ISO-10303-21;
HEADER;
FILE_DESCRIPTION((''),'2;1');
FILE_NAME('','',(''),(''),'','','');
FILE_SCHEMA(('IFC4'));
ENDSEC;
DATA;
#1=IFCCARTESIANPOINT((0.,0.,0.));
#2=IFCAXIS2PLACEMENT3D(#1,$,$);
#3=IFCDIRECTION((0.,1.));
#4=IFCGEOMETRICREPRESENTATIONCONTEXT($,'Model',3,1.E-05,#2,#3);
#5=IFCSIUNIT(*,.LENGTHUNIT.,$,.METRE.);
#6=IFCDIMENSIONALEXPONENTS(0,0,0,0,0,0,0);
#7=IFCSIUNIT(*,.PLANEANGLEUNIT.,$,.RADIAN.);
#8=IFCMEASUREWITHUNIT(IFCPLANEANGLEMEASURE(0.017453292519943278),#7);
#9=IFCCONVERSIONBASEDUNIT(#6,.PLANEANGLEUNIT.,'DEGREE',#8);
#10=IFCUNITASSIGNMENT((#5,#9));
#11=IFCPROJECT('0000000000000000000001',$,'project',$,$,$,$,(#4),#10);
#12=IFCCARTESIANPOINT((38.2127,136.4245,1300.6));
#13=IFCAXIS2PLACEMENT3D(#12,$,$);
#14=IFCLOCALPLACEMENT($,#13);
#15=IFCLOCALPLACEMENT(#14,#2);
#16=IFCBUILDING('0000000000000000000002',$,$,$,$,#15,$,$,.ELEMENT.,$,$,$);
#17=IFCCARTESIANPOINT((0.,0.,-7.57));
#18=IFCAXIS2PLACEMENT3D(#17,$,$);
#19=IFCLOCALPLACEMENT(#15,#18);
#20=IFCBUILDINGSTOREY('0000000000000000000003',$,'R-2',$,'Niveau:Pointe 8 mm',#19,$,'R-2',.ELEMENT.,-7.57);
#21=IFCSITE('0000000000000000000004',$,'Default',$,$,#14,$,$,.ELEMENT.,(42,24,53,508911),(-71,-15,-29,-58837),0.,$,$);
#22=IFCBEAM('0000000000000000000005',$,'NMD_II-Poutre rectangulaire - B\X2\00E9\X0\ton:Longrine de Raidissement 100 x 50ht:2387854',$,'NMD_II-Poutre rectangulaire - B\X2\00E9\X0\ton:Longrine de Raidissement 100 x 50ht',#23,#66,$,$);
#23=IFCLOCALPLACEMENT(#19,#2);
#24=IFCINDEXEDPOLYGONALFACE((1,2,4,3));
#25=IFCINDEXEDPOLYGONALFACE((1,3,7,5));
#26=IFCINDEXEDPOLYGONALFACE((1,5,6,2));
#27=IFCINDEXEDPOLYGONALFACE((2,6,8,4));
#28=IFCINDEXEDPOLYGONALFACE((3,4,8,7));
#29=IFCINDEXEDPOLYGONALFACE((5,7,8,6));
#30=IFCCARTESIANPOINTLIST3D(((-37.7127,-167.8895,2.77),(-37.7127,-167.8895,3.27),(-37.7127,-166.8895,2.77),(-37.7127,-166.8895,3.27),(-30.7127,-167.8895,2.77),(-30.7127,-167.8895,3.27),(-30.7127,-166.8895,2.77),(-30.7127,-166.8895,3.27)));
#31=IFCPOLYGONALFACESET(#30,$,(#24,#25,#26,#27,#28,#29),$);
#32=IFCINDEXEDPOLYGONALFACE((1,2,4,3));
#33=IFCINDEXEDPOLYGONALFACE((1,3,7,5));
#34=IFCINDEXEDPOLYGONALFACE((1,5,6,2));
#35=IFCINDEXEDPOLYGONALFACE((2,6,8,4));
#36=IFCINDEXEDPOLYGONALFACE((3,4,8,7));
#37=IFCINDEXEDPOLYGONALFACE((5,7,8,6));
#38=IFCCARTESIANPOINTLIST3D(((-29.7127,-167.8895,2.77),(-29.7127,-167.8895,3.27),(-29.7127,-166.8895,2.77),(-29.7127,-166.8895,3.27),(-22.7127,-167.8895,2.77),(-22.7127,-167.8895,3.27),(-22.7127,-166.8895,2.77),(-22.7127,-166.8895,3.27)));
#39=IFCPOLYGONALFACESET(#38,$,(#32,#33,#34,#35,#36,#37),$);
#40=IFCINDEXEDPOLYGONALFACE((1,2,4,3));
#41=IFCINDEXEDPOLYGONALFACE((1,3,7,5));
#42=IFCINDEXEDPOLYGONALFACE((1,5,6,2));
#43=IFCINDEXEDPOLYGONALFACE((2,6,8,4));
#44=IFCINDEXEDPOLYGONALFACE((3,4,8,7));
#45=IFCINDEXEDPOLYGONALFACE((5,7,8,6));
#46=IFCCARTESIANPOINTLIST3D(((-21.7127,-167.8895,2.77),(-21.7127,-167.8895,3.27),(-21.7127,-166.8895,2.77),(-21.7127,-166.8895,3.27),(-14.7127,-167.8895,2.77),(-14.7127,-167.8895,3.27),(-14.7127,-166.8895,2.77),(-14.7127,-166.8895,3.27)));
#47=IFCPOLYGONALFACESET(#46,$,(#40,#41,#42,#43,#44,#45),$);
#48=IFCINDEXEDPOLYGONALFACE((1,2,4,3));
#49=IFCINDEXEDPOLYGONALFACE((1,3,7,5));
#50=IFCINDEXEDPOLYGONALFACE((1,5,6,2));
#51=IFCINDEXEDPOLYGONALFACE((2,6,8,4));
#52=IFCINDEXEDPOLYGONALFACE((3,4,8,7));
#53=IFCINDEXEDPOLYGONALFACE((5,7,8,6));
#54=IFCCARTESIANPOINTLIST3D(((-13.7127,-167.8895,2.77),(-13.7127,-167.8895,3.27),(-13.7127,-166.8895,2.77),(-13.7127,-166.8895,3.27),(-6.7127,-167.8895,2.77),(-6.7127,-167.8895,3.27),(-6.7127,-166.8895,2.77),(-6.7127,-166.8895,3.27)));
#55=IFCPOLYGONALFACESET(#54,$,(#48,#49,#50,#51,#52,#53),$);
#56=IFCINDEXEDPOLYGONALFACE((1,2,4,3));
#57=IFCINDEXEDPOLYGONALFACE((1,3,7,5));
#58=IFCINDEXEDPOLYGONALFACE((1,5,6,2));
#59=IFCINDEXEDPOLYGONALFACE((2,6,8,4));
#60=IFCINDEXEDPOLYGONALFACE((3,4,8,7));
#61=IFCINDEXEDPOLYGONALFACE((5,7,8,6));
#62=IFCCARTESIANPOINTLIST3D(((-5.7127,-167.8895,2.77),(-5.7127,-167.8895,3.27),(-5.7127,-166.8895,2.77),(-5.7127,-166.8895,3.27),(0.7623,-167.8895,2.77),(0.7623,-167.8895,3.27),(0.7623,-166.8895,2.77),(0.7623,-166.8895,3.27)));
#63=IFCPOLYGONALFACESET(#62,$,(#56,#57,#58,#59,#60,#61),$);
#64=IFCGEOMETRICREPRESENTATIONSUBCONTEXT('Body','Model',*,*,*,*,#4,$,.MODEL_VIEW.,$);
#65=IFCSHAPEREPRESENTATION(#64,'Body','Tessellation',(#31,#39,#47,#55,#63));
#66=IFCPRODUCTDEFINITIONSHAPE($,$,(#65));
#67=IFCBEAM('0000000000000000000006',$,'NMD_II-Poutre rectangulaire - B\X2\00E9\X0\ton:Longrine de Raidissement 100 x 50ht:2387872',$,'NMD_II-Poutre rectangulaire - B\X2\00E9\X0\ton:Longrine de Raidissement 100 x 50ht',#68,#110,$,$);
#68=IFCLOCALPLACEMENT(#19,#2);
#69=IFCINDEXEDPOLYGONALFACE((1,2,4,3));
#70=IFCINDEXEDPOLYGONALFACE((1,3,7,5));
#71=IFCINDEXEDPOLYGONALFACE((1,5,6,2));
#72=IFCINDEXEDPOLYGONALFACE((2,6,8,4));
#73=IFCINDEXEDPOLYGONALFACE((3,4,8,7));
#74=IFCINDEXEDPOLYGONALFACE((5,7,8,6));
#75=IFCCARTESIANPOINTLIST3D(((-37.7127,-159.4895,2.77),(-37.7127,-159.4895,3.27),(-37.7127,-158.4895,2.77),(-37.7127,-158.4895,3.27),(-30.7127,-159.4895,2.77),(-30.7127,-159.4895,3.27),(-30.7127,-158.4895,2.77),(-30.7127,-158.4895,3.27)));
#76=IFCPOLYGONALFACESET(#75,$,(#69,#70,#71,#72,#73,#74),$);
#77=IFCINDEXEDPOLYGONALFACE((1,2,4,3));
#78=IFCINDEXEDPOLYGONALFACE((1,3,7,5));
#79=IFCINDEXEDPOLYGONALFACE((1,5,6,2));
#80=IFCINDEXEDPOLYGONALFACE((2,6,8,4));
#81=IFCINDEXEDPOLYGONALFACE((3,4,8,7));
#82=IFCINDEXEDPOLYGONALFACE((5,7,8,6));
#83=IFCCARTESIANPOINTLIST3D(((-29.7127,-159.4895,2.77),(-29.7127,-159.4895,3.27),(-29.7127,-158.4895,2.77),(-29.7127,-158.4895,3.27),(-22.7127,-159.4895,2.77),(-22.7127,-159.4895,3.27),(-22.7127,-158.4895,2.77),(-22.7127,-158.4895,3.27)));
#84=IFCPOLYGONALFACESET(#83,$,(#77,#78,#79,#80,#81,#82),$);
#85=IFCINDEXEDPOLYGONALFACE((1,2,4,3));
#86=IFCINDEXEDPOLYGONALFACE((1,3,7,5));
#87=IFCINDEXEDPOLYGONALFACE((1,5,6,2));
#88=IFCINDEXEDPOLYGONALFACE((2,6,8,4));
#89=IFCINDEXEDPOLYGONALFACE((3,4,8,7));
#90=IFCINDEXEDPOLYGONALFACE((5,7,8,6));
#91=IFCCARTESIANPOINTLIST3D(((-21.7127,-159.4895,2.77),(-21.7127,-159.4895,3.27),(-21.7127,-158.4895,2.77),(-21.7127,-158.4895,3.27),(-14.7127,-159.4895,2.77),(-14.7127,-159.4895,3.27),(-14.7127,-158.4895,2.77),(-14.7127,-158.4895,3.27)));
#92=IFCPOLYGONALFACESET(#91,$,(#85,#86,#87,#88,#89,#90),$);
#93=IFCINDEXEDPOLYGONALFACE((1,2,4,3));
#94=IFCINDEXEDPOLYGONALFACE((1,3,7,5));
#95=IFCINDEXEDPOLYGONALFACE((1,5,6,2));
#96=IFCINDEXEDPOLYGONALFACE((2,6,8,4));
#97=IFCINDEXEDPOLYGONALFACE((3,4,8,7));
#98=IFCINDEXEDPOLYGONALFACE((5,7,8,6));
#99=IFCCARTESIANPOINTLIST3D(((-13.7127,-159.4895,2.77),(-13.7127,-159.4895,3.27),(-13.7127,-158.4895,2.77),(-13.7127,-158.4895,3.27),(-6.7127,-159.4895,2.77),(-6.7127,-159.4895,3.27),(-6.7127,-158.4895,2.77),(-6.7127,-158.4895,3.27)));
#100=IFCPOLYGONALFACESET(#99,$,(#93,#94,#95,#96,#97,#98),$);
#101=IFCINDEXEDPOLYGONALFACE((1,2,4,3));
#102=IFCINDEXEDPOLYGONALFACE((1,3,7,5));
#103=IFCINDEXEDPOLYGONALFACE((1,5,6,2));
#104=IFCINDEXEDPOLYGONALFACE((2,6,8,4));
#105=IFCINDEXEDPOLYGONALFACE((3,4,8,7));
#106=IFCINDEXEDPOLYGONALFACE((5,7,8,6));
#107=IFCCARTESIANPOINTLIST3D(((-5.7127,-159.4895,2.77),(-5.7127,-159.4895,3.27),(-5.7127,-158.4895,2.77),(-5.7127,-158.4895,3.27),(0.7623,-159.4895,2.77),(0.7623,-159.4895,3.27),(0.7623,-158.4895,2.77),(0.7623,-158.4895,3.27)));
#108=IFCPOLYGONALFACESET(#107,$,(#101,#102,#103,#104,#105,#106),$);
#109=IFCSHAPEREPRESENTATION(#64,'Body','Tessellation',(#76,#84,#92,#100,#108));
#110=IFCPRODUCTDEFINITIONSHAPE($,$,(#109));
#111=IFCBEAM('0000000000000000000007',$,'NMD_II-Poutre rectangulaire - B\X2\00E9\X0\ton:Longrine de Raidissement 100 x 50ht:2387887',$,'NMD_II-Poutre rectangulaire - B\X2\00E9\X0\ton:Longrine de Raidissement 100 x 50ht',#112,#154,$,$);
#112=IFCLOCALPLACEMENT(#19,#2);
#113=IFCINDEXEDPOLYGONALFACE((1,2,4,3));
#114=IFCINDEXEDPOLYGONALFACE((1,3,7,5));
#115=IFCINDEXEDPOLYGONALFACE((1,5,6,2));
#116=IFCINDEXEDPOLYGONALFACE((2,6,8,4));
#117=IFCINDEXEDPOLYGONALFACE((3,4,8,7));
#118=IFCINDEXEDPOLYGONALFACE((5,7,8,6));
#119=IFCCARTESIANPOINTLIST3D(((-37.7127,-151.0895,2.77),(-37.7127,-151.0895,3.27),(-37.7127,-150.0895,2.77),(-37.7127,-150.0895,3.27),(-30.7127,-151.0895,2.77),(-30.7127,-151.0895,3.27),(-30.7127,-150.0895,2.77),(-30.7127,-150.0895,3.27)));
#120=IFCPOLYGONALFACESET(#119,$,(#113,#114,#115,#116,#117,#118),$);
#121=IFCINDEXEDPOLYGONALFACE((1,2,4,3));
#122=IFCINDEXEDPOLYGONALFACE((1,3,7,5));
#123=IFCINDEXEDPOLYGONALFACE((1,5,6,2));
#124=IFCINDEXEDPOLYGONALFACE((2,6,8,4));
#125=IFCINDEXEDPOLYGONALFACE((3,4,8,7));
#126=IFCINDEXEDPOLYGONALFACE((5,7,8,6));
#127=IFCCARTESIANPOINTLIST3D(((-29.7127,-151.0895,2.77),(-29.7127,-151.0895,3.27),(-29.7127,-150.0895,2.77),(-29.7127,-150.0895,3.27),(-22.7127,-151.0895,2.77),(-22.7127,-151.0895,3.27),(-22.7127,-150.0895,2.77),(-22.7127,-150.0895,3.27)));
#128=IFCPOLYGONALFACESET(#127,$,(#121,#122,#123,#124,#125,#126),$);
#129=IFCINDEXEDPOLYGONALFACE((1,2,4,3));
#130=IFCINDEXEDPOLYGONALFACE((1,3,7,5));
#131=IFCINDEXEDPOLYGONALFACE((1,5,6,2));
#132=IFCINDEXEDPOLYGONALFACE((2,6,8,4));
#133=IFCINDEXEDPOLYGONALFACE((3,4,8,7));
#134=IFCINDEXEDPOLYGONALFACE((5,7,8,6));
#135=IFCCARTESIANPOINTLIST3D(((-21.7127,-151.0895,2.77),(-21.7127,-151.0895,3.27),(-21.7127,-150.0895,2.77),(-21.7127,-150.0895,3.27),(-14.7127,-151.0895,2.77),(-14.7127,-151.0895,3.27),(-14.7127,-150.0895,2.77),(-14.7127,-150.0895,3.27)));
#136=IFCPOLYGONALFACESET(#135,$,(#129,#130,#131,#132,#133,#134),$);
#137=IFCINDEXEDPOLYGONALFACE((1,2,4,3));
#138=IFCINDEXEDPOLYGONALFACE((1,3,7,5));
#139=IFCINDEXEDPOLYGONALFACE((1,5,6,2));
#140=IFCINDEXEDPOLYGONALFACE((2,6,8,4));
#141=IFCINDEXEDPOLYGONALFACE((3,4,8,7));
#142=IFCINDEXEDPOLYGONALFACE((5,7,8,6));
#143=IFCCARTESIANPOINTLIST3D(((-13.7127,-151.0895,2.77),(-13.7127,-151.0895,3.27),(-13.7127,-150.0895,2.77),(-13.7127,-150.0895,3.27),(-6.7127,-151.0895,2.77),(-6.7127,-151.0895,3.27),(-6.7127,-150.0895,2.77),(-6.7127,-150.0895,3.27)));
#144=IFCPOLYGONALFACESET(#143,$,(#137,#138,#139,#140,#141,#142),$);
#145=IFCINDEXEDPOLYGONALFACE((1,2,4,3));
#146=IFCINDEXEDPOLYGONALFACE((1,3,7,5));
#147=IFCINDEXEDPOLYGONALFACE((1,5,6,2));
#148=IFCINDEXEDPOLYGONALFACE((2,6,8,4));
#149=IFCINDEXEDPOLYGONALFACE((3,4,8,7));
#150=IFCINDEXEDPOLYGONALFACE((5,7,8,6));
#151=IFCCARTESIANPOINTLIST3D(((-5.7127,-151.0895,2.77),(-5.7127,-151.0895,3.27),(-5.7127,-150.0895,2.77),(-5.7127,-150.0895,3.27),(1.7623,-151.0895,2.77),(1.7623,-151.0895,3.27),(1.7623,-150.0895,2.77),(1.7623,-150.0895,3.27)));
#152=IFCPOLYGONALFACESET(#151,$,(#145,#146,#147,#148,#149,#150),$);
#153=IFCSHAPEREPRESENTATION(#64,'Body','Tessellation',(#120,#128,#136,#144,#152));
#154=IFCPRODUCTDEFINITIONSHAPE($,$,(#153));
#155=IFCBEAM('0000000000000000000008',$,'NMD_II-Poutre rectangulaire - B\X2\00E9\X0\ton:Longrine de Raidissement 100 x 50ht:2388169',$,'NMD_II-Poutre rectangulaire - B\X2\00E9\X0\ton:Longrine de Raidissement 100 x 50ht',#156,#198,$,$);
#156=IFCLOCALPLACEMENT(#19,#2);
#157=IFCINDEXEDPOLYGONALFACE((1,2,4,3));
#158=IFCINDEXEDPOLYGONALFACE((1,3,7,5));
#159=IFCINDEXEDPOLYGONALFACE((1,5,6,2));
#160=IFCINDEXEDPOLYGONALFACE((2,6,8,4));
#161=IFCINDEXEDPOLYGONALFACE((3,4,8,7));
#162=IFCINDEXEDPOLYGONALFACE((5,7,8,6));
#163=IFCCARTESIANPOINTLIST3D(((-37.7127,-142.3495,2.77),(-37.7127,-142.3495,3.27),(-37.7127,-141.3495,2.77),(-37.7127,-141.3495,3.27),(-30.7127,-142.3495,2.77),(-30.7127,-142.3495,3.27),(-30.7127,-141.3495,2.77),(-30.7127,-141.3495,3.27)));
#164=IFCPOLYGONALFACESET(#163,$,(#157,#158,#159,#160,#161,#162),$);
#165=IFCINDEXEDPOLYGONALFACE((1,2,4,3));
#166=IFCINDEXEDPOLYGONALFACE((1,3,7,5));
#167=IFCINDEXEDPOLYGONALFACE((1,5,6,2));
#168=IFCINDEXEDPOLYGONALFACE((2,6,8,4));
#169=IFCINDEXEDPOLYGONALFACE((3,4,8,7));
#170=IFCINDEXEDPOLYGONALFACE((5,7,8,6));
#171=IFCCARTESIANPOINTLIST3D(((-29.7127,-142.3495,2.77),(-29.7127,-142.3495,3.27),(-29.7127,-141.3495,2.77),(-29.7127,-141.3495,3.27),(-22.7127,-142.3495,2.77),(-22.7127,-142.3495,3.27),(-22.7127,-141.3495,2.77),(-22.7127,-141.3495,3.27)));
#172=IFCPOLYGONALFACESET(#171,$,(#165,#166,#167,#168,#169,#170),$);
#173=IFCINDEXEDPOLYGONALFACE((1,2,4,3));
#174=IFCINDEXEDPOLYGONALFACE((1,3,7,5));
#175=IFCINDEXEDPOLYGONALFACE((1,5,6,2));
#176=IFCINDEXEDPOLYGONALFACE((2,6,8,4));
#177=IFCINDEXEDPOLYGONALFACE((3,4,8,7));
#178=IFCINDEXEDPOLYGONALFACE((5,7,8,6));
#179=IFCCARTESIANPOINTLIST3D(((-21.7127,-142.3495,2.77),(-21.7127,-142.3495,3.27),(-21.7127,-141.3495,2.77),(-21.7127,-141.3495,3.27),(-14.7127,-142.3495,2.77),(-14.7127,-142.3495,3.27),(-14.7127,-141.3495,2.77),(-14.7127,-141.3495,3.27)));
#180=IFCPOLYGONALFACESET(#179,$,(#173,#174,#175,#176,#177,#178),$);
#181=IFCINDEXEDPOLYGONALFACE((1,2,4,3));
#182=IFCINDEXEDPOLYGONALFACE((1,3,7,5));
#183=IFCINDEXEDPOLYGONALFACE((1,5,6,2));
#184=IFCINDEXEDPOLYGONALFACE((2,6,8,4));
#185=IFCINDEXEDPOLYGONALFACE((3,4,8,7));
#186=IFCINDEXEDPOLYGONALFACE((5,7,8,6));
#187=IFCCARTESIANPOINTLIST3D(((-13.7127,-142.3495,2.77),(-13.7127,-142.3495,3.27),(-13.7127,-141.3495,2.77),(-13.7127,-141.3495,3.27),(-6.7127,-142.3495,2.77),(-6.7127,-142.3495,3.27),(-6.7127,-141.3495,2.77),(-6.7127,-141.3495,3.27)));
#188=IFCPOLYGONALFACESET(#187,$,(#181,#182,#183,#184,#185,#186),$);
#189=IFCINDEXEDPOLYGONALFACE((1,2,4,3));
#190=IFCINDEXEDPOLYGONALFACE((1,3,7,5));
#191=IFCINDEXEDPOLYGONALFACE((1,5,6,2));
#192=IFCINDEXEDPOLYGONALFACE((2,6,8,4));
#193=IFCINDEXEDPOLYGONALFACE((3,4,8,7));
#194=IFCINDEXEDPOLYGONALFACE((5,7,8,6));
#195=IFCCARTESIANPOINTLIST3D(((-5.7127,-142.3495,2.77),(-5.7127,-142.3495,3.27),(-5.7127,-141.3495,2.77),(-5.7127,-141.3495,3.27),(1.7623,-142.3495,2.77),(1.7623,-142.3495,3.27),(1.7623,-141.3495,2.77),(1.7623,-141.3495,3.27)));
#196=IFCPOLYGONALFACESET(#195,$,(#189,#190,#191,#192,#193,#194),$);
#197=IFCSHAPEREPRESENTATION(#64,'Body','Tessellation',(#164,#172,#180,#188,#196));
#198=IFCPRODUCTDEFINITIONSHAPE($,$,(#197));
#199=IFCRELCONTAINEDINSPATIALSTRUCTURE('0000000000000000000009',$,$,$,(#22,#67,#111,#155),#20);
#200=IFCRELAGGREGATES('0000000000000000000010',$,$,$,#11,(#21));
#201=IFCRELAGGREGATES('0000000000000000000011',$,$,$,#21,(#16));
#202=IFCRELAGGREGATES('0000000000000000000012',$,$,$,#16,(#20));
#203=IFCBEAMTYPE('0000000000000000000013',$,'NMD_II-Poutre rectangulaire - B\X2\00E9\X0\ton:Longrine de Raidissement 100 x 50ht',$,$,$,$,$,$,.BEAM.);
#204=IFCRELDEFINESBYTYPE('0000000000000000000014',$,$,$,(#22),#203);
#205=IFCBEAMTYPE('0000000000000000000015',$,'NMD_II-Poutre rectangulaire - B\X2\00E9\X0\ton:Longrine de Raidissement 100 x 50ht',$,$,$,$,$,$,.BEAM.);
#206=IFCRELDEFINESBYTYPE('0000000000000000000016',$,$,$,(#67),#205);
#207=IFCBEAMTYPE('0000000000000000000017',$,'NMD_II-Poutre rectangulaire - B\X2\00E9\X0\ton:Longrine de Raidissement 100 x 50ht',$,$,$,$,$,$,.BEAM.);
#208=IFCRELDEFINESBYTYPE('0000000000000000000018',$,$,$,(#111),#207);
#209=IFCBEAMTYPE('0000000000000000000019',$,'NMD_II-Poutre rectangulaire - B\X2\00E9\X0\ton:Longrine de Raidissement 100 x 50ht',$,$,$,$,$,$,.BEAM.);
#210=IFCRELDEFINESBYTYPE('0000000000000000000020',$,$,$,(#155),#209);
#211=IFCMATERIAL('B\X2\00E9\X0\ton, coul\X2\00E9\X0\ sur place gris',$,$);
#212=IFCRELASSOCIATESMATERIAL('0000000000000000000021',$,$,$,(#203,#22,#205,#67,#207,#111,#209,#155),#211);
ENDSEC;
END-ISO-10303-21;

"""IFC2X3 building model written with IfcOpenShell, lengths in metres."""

from ifc_helpers import new_model, entity, si_unit, converted_unit, direction, frame, frame_2d, origin, place, context, subcontext, project, spatial, rectangle, extrude, source, transform, mapped, material, type_object, type_shapes, element, save


model = new_model("IFC2X3")

# Units and contexts
model_context = context("Model", 3, precision=1e-05, world=origin(), true_north=direction((0.0, 1.0)))
body_context = subcontext(model_context, "Body", "Model", "MODEL_VIEW")
ifc_project = project(units=[si_unit("LENGTHUNIT", "METRE"), converted_unit("PLANEANGLEUNIT", "DEGREE", entity("IfcPlaneAngleMeasure", 0.017453292519943278), si_unit("PLANEANGLEUNIT", "RADIAN"), dimensions=[0, 0, 0, 0, 0, 0, 0])], contexts=[model_context])

# Site, building, storey
site_placement = place(None, frame((38.2127, 136.4245, 1300.6)))
site = spatial("IfcSite", under=ifc_project, at=site_placement, Name="Default", CompositionType="ELEMENT", RefLatitude=(42, 24, 53, 508911), RefLongitude=(-71, -15, -29, -58837), RefElevation=0.0)
building_placement = place(site_placement, origin())
building = spatial("IfcBuilding", under=site, at=building_placement, CompositionType="ELEMENT")
storey_placement = place(building_placement, frame((0.0, 0.0, -7.57)))
storey = spatial("IfcBuildingStorey", under=building, at=storey_placement, Name="R-2", ObjectType="Niveau:Pointe 8 mm", LongName="R-2", CompositionType="ELEMENT", Elevation=-7.57)

# Beams
ifc_material_1 = material(Name="Béton, coulé sur place gris")
beam_type_1 = type_object("IfcBeamType", Name="NMD_II-Poutre rectangulaire - Béton:Longrine de Raidissement 100 x 50ht", PredefinedType="BEAM", material=ifc_material_1)
shared_shape_1 = source(origin(), body_context, "Body", "SweptSolid", [
    extrude(rectangle(XDim=0.5, YDim=1.0, at=frame_2d((0.0, 0.0), x_axis=(1.0, 0.0))), frame((-30.7127, -167.3895, -4.55), z_axis=(-1.0, 0.0, 0.0), x_axis=(0.0, 0.0, -1.0)), (0.0, 0.0, 1.0), 7.0),
    extrude(rectangle(XDim=0.5, YDim=1.0, at=frame_2d((0.0, 0.0), x_axis=(1.0, 0.0))), frame((-22.7127, -167.3895, -4.55), z_axis=(-1.0, 0.0, 0.0), x_axis=(0.0, 0.0, -1.0)), (0.0, 0.0, 1.0), 7.0),
    extrude(rectangle(XDim=0.5, YDim=1.0, at=frame_2d((0.0, 0.0), x_axis=(1.0, 0.0))), frame((-14.7127, -167.3895, -4.55), z_axis=(-1.0, 0.0, 0.0), x_axis=(0.0, 0.0, -1.0)), (0.0, 0.0, 1.0), 7.0),
    extrude(rectangle(XDim=0.5, YDim=1.0, at=frame_2d((0.0, 0.0), x_axis=(1.0, 0.0))), frame((-6.7127, -167.3895, -4.55), z_axis=(-1.0, 0.0, 0.0), x_axis=(0.0, 0.0, -1.0)), (0.0, 0.0, 1.0), 7.0),
    extrude(rectangle(XDim=0.5, YDim=1.0, at=frame_2d((0.0, 0.0), x_axis=(1.0, 0.0))), frame((0.7623, -167.3895, -4.55), z_axis=(-1.0, 0.0, 0.0), x_axis=(0.0, 0.0, -1.0)), (0.0, 0.0, 1.0), 6.475),
])
type_shapes(beam_type_1, [shared_shape_1])
beam_1_placement = place(storey_placement, frame((0.0, 0.0, 7.57)))
element("IfcBeam", 1, at=beam_1_placement, inside=storey, type_object=beam_type_1, material=ifc_material_1, Name="NMD_II-Poutre rectangulaire - Béton:Longrine de Raidissement 100 x 50ht:2387854", ObjectType="NMD_II-Poutre rectangulaire - Béton:Longrine de Raidissement 100 x 50ht", context=body_context, shape_type="MappedRepresentation", body=[
    mapped(shared_shape_1, transform((0.0, 0.0, 0.0), scale=1.0)),
])
beam_type_2 = type_object("IfcBeamType", Name="NMD_II-Poutre rectangulaire - Béton:Longrine de Raidissement 100 x 50ht", PredefinedType="BEAM", material=ifc_material_1)
shared_shape_2 = source(origin(), body_context, "Body", "SweptSolid", [
    extrude(rectangle(XDim=0.5, YDim=1.0, at=frame_2d((0.0, 0.0), x_axis=(1.0, 0.0))), frame((-30.7127, -158.9895, -4.55), z_axis=(-1.0, 0.0, 0.0), x_axis=(0.0, 0.0, -1.0)), (0.0, 0.0, 1.0), 7.0),
    extrude(rectangle(XDim=0.5, YDim=1.0, at=frame_2d((0.0, 0.0), x_axis=(1.0, 0.0))), frame((-22.7127, -158.9895, -4.55), z_axis=(-1.0, 0.0, 0.0), x_axis=(0.0, 0.0, -1.0)), (0.0, 0.0, 1.0), 7.0),
    extrude(rectangle(XDim=0.5, YDim=1.0, at=frame_2d((0.0, 0.0), x_axis=(1.0, 0.0))), frame((-14.7127, -158.9895, -4.55), z_axis=(-1.0, 0.0, 0.0), x_axis=(0.0, 0.0, -1.0)), (0.0, 0.0, 1.0), 7.0),
    extrude(rectangle(XDim=0.5, YDim=1.0, at=frame_2d((0.0, 0.0), x_axis=(1.0, 0.0))), frame((-6.7127, -158.9895, -4.55), z_axis=(-1.0, 0.0, 0.0), x_axis=(0.0, 0.0, -1.0)), (0.0, 0.0, 1.0), 7.0),
    extrude(rectangle(XDim=0.5, YDim=1.0, at=frame_2d((0.0, 0.0), x_axis=(1.0, 0.0))), frame((0.7623, -158.9895, -4.55), z_axis=(-1.0, 0.0, 0.0), x_axis=(0.0, 0.0, -1.0)), (0.0, 0.0, 1.0), 6.475),
])
type_shapes(beam_type_2, [shared_shape_2])
beam_2_placement = place(storey_placement, frame((0.0, 0.0, 7.57)))
element("IfcBeam", 2, at=beam_2_placement, inside=storey, type_object=beam_type_2, material=ifc_material_1, Name="NMD_II-Poutre rectangulaire - Béton:Longrine de Raidissement 100 x 50ht:2387872", ObjectType="NMD_II-Poutre rectangulaire - Béton:Longrine de Raidissement 100 x 50ht", context=body_context, shape_type="MappedRepresentation", body=[
    mapped(shared_shape_2, transform((0.0, 0.0, 0.0), scale=1.0)),
])
beam_type_3 = type_object("IfcBeamType", Name="NMD_II-Poutre rectangulaire - Béton:Longrine de Raidissement 100 x 50ht", PredefinedType="BEAM", material=ifc_material_1)
shared_shape_3 = source(origin(), body_context, "Body", "SweptSolid", [
    extrude(rectangle(XDim=0.5, YDim=1.0, at=frame_2d((0.0, 0.0), x_axis=(1.0, 0.0))), frame((-30.7127, -150.5895, -4.55), z_axis=(-1.0, 0.0, 0.0), x_axis=(0.0, 0.0, -1.0)), (0.0, 0.0, 1.0), 7.0),
    extrude(rectangle(XDim=0.5, YDim=1.0, at=frame_2d((0.0, 0.0), x_axis=(1.0, 0.0))), frame((-22.7127, -150.5895, -4.55), z_axis=(-1.0, 0.0, 0.0), x_axis=(0.0, 0.0, -1.0)), (0.0, 0.0, 1.0), 7.0),
    extrude(rectangle(XDim=0.5, YDim=1.0, at=frame_2d((0.0, 0.0), x_axis=(1.0, 0.0))), frame((-14.7127, -150.5895, -4.55), z_axis=(-1.0, 0.0, 0.0), x_axis=(0.0, 0.0, -1.0)), (0.0, 0.0, 1.0), 7.0),
    extrude(rectangle(XDim=0.5, YDim=1.0, at=frame_2d((0.0, 0.0), x_axis=(1.0, 0.0))), frame((-6.7127, -150.5895, -4.55), z_axis=(-1.0, 0.0, 0.0), x_axis=(0.0, 0.0, -1.0)), (0.0, 0.0, 1.0), 7.0),
    extrude(rectangle(XDim=0.5, YDim=1.0, at=frame_2d((0.0, 0.0), x_axis=(1.0, 0.0))), frame((1.7623, -150.5895, -4.55), z_axis=(-1.0, 0.0, 0.0), x_axis=(0.0, 0.0, -1.0)), (0.0, 0.0, 1.0), 7.475),
])
type_shapes(beam_type_3, [shared_shape_3])
beam_3_placement = place(storey_placement, frame((0.0, 0.0, 7.57)))
element("IfcBeam", 3, at=beam_3_placement, inside=storey, type_object=beam_type_3, material=ifc_material_1, Name="NMD_II-Poutre rectangulaire - Béton:Longrine de Raidissement 100 x 50ht:2387887", ObjectType="NMD_II-Poutre rectangulaire - Béton:Longrine de Raidissement 100 x 50ht", context=body_context, shape_type="MappedRepresentation", body=[
    mapped(shared_shape_3, transform((0.0, 0.0, 0.0), scale=1.0)),
])
beam_type_4 = type_object("IfcBeamType", Name="NMD_II-Poutre rectangulaire - Béton:Longrine de Raidissement 100 x 50ht", PredefinedType="BEAM", material=ifc_material_1)
shared_shape_4 = source(origin(), body_context, "Body", "SweptSolid", [
    extrude(rectangle(XDim=0.5, YDim=1.0, at=frame_2d((0.0, 0.0), x_axis=(1.0, 0.0))), frame((-30.7127, -141.8495, -4.55), z_axis=(-1.0, 0.0, 0.0), x_axis=(0.0, 0.0, -1.0)), (0.0, 0.0, 1.0), 7.0),
    extrude(rectangle(XDim=0.5, YDim=1.0, at=frame_2d((0.0, 0.0), x_axis=(1.0, 0.0))), frame((-22.7127, -141.8495, -4.55), z_axis=(-1.0, 0.0, 0.0), x_axis=(0.0, 0.0, -1.0)), (0.0, 0.0, 1.0), 7.0),
    extrude(rectangle(XDim=0.5, YDim=1.0, at=frame_2d((0.0, 0.0), x_axis=(1.0, 0.0))), frame((-14.7127, -141.8495, -4.55), z_axis=(-1.0, 0.0, 0.0), x_axis=(0.0, 0.0, -1.0)), (0.0, 0.0, 1.0), 7.0),
    extrude(rectangle(XDim=0.5, YDim=1.0, at=frame_2d((0.0, 0.0), x_axis=(1.0, 0.0))), frame((-6.7127, -141.8495, -4.55), z_axis=(-1.0, 0.0, 0.0), x_axis=(0.0, 0.0, -1.0)), (0.0, 0.0, 1.0), 7.0),
    extrude(rectangle(XDim=0.5, YDim=1.0, at=frame_2d((0.0, 0.0), x_axis=(1.0, 0.0))), frame((1.7623, -141.8495, -4.55), z_axis=(-1.0, 0.0, 0.0), x_axis=(0.0, 0.0, -1.0)), (0.0, 0.0, 1.0), 7.475),
])
type_shapes(beam_type_4, [shared_shape_4])
beam_4_placement = place(storey_placement, frame((0.0, 0.0, 7.57)))
element("IfcBeam", 4, at=beam_4_placement, inside=storey, type_object=beam_type_4, material=ifc_material_1, Name="NMD_II-Poutre rectangulaire - Béton:Longrine de Raidissement 100 x 50ht:2388169", ObjectType="NMD_II-Poutre rectangulaire - Béton:Longrine de Raidissement 100 x 50ht", context=body_context, shape_type="MappedRepresentation", body=[
    mapped(shared_shape_4, transform((0.0, 0.0, 0.0), scale=1.0)),
])

save(model, "model.ifc")
